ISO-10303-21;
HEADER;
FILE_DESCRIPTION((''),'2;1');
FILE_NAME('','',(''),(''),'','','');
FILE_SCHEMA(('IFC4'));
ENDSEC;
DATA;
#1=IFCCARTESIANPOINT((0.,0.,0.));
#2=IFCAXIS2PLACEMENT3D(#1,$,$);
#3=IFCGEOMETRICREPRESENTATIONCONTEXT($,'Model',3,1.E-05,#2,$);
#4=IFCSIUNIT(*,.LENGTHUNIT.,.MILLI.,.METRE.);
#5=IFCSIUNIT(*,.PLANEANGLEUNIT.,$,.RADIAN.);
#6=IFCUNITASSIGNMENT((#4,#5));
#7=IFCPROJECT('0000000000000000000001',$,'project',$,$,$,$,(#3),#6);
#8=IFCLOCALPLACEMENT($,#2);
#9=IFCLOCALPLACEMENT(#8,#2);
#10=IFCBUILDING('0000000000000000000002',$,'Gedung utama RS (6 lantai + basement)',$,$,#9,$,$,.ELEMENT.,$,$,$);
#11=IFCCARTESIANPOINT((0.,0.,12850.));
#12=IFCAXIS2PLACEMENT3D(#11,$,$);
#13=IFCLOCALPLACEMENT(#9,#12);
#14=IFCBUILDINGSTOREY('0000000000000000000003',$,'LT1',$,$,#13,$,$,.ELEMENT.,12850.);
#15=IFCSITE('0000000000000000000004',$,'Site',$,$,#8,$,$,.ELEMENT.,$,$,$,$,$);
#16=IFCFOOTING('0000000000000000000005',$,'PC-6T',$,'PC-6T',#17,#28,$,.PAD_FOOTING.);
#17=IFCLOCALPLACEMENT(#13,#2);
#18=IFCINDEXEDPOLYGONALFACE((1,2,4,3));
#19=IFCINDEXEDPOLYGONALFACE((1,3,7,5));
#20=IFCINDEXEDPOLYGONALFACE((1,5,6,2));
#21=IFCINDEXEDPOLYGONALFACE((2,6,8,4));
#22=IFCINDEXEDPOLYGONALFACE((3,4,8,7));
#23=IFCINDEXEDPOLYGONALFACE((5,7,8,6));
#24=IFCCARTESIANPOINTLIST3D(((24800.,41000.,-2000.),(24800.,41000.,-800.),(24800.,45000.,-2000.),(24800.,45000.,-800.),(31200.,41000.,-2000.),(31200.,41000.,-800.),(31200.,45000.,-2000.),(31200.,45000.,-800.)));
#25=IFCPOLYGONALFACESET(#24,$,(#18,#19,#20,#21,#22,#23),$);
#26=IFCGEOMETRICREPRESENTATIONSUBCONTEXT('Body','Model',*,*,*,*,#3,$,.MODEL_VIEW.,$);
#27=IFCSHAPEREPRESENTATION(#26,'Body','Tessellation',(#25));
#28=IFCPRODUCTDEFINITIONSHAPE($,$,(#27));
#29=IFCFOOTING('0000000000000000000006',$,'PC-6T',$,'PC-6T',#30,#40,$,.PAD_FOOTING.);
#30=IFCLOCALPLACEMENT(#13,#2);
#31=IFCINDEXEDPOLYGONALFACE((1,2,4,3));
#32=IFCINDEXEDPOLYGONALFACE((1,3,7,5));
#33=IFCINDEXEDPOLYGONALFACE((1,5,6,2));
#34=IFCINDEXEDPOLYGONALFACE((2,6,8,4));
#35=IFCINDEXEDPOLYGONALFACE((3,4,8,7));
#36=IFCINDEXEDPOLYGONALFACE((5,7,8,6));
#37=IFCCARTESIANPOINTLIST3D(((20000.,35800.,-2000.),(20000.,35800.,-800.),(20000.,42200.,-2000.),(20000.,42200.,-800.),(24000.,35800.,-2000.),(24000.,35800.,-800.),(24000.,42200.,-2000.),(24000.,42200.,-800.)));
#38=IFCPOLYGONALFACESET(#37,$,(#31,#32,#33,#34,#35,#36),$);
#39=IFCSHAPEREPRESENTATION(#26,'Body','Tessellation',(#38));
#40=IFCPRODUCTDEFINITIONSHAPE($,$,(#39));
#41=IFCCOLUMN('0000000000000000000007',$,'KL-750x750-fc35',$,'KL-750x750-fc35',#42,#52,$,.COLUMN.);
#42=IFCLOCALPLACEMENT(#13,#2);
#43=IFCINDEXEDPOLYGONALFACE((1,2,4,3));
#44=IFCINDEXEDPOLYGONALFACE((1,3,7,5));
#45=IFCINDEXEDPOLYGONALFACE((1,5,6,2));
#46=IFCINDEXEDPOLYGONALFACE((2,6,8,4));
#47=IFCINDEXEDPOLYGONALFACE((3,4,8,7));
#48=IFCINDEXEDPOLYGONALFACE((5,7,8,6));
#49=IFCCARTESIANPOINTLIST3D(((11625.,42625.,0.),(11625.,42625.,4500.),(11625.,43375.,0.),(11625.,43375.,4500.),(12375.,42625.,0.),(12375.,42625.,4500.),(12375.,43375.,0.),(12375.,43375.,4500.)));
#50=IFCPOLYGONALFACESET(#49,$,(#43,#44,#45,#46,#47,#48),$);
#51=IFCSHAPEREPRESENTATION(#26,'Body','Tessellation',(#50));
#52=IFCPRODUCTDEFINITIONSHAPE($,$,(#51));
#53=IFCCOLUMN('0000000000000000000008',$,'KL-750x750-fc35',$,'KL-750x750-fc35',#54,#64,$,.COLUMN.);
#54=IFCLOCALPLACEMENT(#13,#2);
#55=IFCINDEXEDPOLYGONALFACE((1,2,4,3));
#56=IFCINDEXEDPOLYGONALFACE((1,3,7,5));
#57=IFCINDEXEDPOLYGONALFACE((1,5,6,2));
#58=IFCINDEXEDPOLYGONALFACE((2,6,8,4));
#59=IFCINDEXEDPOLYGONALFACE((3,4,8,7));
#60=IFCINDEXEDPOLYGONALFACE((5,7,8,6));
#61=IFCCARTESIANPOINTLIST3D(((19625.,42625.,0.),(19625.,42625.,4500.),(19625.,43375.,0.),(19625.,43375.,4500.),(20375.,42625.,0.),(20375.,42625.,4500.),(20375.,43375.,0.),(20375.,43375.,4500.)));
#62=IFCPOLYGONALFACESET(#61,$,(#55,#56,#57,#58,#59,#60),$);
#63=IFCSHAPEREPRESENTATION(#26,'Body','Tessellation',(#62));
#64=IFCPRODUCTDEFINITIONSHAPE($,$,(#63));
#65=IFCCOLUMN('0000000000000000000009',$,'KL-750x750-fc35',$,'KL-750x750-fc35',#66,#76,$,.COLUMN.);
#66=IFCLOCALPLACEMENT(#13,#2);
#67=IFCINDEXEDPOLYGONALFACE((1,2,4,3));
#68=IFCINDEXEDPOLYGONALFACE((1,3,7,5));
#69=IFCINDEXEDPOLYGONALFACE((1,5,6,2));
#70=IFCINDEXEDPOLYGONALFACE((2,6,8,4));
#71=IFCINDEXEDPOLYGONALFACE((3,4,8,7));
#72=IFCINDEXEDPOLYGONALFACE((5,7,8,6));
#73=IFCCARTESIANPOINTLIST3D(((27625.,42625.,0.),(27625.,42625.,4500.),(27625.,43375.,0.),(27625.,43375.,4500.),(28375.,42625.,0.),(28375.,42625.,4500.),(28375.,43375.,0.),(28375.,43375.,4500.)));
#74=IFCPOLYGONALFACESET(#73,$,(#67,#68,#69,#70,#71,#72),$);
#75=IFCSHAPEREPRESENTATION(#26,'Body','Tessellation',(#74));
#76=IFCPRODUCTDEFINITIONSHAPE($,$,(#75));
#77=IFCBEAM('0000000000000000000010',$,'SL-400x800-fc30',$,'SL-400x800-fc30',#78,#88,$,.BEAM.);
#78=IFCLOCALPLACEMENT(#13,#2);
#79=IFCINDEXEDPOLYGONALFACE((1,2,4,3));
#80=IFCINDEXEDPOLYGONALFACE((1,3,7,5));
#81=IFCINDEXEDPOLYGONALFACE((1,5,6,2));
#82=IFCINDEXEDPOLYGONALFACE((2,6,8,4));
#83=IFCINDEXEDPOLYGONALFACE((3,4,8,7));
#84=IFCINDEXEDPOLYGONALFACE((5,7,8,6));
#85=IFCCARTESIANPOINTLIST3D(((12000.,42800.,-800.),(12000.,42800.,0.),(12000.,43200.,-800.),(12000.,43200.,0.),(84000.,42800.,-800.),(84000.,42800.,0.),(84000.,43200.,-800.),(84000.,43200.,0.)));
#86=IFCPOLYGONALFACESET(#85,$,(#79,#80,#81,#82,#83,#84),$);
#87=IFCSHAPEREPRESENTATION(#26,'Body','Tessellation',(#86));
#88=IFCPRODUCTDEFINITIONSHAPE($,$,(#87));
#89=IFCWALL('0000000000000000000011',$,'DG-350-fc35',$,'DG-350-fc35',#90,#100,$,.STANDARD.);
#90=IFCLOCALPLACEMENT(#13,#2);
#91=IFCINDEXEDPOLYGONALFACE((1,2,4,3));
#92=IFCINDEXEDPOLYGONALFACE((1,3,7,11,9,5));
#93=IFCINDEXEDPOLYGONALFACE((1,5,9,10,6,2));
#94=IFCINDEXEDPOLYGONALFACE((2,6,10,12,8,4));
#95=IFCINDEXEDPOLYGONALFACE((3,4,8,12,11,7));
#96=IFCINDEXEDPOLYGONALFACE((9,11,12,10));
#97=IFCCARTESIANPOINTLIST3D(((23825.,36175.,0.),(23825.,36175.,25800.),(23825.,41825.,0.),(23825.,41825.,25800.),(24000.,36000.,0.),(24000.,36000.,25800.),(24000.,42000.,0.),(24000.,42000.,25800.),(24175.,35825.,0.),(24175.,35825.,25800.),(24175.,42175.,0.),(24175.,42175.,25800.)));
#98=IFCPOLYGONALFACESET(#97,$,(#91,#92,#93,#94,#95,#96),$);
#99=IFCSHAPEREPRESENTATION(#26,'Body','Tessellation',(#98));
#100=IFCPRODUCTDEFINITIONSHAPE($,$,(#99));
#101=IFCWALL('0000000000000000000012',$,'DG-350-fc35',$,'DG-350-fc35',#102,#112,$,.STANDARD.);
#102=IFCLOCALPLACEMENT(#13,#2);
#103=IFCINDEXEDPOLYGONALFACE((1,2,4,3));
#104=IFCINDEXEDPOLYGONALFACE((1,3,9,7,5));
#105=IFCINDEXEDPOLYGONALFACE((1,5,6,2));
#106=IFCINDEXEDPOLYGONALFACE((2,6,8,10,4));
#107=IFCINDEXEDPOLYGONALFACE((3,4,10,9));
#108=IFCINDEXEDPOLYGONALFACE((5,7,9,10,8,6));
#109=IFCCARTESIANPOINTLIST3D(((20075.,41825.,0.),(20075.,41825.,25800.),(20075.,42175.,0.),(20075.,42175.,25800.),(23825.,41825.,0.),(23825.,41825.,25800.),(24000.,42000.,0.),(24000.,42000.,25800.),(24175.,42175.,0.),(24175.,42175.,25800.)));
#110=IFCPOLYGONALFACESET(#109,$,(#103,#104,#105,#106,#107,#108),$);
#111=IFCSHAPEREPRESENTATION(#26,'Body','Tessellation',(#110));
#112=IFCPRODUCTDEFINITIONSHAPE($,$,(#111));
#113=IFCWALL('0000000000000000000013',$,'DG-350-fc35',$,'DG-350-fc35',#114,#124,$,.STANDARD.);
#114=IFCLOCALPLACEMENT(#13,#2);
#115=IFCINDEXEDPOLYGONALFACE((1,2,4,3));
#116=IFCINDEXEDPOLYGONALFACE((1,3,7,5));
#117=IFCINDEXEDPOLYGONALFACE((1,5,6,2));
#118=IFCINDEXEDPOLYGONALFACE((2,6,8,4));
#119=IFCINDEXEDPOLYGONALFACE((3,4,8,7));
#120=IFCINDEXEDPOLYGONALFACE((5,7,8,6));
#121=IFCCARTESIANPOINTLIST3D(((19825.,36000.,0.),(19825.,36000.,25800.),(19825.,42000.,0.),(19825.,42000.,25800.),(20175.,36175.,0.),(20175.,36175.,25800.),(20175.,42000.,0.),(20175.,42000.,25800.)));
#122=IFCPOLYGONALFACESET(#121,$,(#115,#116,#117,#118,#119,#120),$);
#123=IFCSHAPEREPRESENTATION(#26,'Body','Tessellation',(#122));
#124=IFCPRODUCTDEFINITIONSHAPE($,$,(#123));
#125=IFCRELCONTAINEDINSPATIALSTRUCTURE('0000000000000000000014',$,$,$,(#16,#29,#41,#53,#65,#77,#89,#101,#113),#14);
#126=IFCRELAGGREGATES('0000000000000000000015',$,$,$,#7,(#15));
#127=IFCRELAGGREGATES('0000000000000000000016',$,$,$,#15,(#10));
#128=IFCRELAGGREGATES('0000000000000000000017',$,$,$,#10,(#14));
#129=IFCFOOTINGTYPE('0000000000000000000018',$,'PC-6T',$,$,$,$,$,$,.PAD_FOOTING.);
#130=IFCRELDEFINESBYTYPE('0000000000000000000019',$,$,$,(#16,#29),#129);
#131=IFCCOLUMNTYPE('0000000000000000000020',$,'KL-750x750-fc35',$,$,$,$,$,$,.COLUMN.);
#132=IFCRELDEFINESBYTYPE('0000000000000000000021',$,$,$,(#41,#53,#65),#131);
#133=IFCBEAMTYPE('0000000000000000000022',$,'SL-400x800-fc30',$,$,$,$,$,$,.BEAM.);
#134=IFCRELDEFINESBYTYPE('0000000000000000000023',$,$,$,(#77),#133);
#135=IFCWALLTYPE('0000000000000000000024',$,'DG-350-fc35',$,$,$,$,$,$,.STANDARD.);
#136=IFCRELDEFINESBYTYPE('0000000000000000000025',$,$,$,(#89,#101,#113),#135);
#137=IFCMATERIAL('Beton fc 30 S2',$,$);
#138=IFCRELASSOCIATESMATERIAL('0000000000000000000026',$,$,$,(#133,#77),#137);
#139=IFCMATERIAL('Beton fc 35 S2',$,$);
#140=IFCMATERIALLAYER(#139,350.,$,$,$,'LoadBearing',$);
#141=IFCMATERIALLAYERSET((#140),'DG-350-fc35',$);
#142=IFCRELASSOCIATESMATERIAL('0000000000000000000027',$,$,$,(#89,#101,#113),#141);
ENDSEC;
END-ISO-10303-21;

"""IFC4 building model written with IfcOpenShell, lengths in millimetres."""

from ifc_helpers import new_model, si_unit, frame, origin, origin_2d, place, context, subcontext, project, spatial, polyline, rectangle, outline, extrude, material, layer, layer_set, layer_usage, material_profile, profile_set, profile_usage, type_object, element, save


model = new_model("IFC4")

# Units and contexts
model_context = context("Model", 3, precision=1e-05, world=origin())
body_context = subcontext(model_context, "Body", "Model", "MODEL_VIEW")
ifc_project = project(units=[si_unit("LENGTHUNIT", "METRE", prefix="MILLI"), si_unit("PLANEANGLEUNIT", "RADIAN")], contexts=[model_context])

# Site, building, storey
site_placement = place(None, origin())
site = spatial("IfcSite", under=ifc_project, at=site_placement, Name="Site", CompositionType="ELEMENT")
building_placement = place(site_placement, origin())
building = spatial("IfcBuilding", under=site, at=building_placement, Name="Gedung utama RS (6 lantai + basement)", CompositionType="ELEMENT")
storey_placement = place(building_placement, frame((0.0, 0.0, 12850.0)))
storey = spatial("IfcBuildingStorey", under=building, at=storey_placement, Name="LT1", CompositionType="ELEMENT", Elevation=12850.0)

# Footings
ifc_material_profile_1 = material_profile(None, rectangle(XDim=6400.0, YDim=4000.0, at=origin_2d()), Name="PC-6T")
ifc_profile_set_1 = profile_set([ifc_material_profile_1], Name="PC-6T")
ifc_profile_usage_1 = profile_usage(ifc_profile_set_1, cardinal=5)
footing_type_1 = type_object("IfcFootingType", Name="PC-6T", PredefinedType="PAD_FOOTING", material=ifc_profile_set_1)
for number, where, z_axis, x_axis, name in (
    (1, (28000.0, 43000.0, -2000.0), (0.0, 0.0, 1.0), (1.0, 0.0, 0.0), "PC-6T"),
    (2, (22000.0, 39000.0, -2000.0), (0.0, 0.0, 1.0), (0.0, 1.0, 0.0), "PC-6T"),
):
    element("IfcFooting", number, at=place(storey_placement, frame(where, z_axis=z_axis, x_axis=x_axis)), inside=storey, type_object=footing_type_1, material=ifc_profile_usage_1, Name=name, ObjectType="PC-6T", PredefinedType="PAD_FOOTING", context=body_context, shape_type="SweptSolid", body=[
        extrude(rectangle(XDim=6400.0, YDim=4000.0, at=origin_2d()), origin(), (0.0, 0.0, 1.0), 1200.0),
    ])

# Columns
ifc_material_profile_2 = material_profile(None, rectangle(XDim=750.0, YDim=750.0, at=origin_2d()), Name="KL-750x750-fc35")
ifc_profile_set_2 = profile_set([ifc_material_profile_2], Name="KL-750x750-fc35")
ifc_profile_usage_2 = profile_usage(ifc_profile_set_2, cardinal=5)
column_type = type_object("IfcColumnType", Name="KL-750x750-fc35", PredefinedType="COLUMN", material=ifc_profile_set_2)
for number, where, z_axis, x_axis, name in (
    (3, (12000.0, 43000.0, 0.0), (0.0, 0.0, 1.0), (1.0, 0.0, 0.0), "KL-750x750-fc35"),
    (4, (20000.0, 43000.0, 0.0), (0.0, 0.0, 1.0), (1.0, 0.0, 0.0), "KL-750x750-fc35"),
    (5, (28000.0, 43000.0, 0.0), (0.0, 0.0, 1.0), (1.0, 0.0, 0.0), "KL-750x750-fc35"),
):
    element("IfcColumn", number, at=place(storey_placement, frame(where, z_axis=z_axis, x_axis=x_axis)), inside=storey, type_object=column_type, material=ifc_profile_usage_2, Name=name, ObjectType="KL-750x750-fc35", PredefinedType="COLUMN", context=body_context, shape_type="SweptSolid", body=[
        extrude(rectangle(XDim=750.0, YDim=750.0, at=origin_2d()), origin(), (0.0, 0.0, 1.0), 4500.0),
    ])

# Beam
ifc_material_1 = material(Name="Beton fc 30 S2")
ifc_material_profile_3 = material_profile(ifc_material_1, rectangle(XDim=400.0, YDim=800.0, at=origin_2d()), Name="SL-400x800-fc30")
ifc_profile_set_3 = profile_set([ifc_material_profile_3], Name="SL-400x800-fc30")
ifc_profile_usage_3 = profile_usage(ifc_profile_set_3, cardinal=8)
beam_type = type_object("IfcBeamType", Name="SL-400x800-fc30", PredefinedType="BEAM", material=ifc_profile_set_3)
beam_placement = place(storey_placement, frame((12000.0, 43000.0, -400.0)))
element("IfcBeam", 6, at=beam_placement, inside=storey, type_object=beam_type, material=ifc_profile_usage_3, Name="SL-400x800-fc30", ObjectType="SL-400x800-fc30", PredefinedType="BEAM", context=body_context, shape_type="SweptSolid", body=[
    extrude(rectangle(XDim=400.0, YDim=800.0, at=origin_2d()), frame((0.0, 0.0, 0.0), z_axis=(1.0, 0.0, 0.0), x_axis=(0.0, 1.0, 0.0)), (0.0, 0.0, 1.0), 72000.0),
])

# Walls
ifc_material_2 = material(Name="Beton fc 35 S2")
ifc_layer = layer(ifc_material_2, 350.0, Category="LoadBearing")
ifc_layer_set = layer_set([ifc_layer], Name="DG-350-fc35")
ifc_layer_usage = layer_usage(ifc_layer_set, "AXIS2", "NEGATIVE", 175.0)
wall_type = type_object("IfcWallType", Name="DG-350-fc35", PredefinedType="STANDARD")
wall_1_placement = place(storey_placement, frame((24000.0, 36000.0, 0.0), z_axis=(0.0, 0.0, 1.0), x_axis=(0.0, 1.0, 0.0)))
element("IfcWall", 7, at=wall_1_placement, inside=storey, type_object=wall_type, material=ifc_layer_usage, Name="DG-350-fc35", ObjectType="DG-350-fc35", PredefinedType="STANDARD", context=body_context, shape_type="SweptSolid", body=[
    extrude(outline(polyline([(-175.0, -175.0), (0.0, 0.0), (175.0, 175.0), (5825.0, 175.0), (6000.0, 0.0), (6175.0, -175.0), (-175.0, -175.0)])), origin(), (0.0, 0.0, 1.0), 25800.0),
])
wall_2_placement = place(storey_placement, frame((24000.0, 42000.0, 0.0), z_axis=(0.0, 0.0, 1.0), x_axis=(-1.0, 0.0, 0.0)))
element("IfcWall", 8, at=wall_2_placement, inside=storey, type_object=wall_type, material=ifc_layer_usage, Name="DG-350-fc35", ObjectType="DG-350-fc35", PredefinedType="STANDARD", context=body_context, shape_type="SweptSolid", body=[
    extrude(outline(polyline([(-175.0, -175.0), (0.0, 0.0), (175.0, 175.0), (3925.0, 175.0), (3925.0, -175.0), (-175.0, -175.0)])), origin(), (0.0, 0.0, 1.0), 25800.0),
])
wall_3_placement = place(storey_placement, frame((20000.0, 42000.0, 0.0), z_axis=(0.0, 0.0, 1.0), x_axis=(0.0, -1.0, 0.0)))
element("IfcWall", 9, at=wall_3_placement, inside=storey, type_object=wall_type, material=ifc_layer_usage, Name="DG-350-fc35", ObjectType="DG-350-fc35", PredefinedType="STANDARD", context=body_context, shape_type="SweptSolid", body=[
    extrude(outline(polyline([(0.0, -175.0), (0.0, 175.0), (5825.0, 175.0), (6000.0, -175.0), (0.0, -175.0)])), origin(), (0.0, 0.0, 1.0), 25800.0),
])

save(model, "model.ifc")
